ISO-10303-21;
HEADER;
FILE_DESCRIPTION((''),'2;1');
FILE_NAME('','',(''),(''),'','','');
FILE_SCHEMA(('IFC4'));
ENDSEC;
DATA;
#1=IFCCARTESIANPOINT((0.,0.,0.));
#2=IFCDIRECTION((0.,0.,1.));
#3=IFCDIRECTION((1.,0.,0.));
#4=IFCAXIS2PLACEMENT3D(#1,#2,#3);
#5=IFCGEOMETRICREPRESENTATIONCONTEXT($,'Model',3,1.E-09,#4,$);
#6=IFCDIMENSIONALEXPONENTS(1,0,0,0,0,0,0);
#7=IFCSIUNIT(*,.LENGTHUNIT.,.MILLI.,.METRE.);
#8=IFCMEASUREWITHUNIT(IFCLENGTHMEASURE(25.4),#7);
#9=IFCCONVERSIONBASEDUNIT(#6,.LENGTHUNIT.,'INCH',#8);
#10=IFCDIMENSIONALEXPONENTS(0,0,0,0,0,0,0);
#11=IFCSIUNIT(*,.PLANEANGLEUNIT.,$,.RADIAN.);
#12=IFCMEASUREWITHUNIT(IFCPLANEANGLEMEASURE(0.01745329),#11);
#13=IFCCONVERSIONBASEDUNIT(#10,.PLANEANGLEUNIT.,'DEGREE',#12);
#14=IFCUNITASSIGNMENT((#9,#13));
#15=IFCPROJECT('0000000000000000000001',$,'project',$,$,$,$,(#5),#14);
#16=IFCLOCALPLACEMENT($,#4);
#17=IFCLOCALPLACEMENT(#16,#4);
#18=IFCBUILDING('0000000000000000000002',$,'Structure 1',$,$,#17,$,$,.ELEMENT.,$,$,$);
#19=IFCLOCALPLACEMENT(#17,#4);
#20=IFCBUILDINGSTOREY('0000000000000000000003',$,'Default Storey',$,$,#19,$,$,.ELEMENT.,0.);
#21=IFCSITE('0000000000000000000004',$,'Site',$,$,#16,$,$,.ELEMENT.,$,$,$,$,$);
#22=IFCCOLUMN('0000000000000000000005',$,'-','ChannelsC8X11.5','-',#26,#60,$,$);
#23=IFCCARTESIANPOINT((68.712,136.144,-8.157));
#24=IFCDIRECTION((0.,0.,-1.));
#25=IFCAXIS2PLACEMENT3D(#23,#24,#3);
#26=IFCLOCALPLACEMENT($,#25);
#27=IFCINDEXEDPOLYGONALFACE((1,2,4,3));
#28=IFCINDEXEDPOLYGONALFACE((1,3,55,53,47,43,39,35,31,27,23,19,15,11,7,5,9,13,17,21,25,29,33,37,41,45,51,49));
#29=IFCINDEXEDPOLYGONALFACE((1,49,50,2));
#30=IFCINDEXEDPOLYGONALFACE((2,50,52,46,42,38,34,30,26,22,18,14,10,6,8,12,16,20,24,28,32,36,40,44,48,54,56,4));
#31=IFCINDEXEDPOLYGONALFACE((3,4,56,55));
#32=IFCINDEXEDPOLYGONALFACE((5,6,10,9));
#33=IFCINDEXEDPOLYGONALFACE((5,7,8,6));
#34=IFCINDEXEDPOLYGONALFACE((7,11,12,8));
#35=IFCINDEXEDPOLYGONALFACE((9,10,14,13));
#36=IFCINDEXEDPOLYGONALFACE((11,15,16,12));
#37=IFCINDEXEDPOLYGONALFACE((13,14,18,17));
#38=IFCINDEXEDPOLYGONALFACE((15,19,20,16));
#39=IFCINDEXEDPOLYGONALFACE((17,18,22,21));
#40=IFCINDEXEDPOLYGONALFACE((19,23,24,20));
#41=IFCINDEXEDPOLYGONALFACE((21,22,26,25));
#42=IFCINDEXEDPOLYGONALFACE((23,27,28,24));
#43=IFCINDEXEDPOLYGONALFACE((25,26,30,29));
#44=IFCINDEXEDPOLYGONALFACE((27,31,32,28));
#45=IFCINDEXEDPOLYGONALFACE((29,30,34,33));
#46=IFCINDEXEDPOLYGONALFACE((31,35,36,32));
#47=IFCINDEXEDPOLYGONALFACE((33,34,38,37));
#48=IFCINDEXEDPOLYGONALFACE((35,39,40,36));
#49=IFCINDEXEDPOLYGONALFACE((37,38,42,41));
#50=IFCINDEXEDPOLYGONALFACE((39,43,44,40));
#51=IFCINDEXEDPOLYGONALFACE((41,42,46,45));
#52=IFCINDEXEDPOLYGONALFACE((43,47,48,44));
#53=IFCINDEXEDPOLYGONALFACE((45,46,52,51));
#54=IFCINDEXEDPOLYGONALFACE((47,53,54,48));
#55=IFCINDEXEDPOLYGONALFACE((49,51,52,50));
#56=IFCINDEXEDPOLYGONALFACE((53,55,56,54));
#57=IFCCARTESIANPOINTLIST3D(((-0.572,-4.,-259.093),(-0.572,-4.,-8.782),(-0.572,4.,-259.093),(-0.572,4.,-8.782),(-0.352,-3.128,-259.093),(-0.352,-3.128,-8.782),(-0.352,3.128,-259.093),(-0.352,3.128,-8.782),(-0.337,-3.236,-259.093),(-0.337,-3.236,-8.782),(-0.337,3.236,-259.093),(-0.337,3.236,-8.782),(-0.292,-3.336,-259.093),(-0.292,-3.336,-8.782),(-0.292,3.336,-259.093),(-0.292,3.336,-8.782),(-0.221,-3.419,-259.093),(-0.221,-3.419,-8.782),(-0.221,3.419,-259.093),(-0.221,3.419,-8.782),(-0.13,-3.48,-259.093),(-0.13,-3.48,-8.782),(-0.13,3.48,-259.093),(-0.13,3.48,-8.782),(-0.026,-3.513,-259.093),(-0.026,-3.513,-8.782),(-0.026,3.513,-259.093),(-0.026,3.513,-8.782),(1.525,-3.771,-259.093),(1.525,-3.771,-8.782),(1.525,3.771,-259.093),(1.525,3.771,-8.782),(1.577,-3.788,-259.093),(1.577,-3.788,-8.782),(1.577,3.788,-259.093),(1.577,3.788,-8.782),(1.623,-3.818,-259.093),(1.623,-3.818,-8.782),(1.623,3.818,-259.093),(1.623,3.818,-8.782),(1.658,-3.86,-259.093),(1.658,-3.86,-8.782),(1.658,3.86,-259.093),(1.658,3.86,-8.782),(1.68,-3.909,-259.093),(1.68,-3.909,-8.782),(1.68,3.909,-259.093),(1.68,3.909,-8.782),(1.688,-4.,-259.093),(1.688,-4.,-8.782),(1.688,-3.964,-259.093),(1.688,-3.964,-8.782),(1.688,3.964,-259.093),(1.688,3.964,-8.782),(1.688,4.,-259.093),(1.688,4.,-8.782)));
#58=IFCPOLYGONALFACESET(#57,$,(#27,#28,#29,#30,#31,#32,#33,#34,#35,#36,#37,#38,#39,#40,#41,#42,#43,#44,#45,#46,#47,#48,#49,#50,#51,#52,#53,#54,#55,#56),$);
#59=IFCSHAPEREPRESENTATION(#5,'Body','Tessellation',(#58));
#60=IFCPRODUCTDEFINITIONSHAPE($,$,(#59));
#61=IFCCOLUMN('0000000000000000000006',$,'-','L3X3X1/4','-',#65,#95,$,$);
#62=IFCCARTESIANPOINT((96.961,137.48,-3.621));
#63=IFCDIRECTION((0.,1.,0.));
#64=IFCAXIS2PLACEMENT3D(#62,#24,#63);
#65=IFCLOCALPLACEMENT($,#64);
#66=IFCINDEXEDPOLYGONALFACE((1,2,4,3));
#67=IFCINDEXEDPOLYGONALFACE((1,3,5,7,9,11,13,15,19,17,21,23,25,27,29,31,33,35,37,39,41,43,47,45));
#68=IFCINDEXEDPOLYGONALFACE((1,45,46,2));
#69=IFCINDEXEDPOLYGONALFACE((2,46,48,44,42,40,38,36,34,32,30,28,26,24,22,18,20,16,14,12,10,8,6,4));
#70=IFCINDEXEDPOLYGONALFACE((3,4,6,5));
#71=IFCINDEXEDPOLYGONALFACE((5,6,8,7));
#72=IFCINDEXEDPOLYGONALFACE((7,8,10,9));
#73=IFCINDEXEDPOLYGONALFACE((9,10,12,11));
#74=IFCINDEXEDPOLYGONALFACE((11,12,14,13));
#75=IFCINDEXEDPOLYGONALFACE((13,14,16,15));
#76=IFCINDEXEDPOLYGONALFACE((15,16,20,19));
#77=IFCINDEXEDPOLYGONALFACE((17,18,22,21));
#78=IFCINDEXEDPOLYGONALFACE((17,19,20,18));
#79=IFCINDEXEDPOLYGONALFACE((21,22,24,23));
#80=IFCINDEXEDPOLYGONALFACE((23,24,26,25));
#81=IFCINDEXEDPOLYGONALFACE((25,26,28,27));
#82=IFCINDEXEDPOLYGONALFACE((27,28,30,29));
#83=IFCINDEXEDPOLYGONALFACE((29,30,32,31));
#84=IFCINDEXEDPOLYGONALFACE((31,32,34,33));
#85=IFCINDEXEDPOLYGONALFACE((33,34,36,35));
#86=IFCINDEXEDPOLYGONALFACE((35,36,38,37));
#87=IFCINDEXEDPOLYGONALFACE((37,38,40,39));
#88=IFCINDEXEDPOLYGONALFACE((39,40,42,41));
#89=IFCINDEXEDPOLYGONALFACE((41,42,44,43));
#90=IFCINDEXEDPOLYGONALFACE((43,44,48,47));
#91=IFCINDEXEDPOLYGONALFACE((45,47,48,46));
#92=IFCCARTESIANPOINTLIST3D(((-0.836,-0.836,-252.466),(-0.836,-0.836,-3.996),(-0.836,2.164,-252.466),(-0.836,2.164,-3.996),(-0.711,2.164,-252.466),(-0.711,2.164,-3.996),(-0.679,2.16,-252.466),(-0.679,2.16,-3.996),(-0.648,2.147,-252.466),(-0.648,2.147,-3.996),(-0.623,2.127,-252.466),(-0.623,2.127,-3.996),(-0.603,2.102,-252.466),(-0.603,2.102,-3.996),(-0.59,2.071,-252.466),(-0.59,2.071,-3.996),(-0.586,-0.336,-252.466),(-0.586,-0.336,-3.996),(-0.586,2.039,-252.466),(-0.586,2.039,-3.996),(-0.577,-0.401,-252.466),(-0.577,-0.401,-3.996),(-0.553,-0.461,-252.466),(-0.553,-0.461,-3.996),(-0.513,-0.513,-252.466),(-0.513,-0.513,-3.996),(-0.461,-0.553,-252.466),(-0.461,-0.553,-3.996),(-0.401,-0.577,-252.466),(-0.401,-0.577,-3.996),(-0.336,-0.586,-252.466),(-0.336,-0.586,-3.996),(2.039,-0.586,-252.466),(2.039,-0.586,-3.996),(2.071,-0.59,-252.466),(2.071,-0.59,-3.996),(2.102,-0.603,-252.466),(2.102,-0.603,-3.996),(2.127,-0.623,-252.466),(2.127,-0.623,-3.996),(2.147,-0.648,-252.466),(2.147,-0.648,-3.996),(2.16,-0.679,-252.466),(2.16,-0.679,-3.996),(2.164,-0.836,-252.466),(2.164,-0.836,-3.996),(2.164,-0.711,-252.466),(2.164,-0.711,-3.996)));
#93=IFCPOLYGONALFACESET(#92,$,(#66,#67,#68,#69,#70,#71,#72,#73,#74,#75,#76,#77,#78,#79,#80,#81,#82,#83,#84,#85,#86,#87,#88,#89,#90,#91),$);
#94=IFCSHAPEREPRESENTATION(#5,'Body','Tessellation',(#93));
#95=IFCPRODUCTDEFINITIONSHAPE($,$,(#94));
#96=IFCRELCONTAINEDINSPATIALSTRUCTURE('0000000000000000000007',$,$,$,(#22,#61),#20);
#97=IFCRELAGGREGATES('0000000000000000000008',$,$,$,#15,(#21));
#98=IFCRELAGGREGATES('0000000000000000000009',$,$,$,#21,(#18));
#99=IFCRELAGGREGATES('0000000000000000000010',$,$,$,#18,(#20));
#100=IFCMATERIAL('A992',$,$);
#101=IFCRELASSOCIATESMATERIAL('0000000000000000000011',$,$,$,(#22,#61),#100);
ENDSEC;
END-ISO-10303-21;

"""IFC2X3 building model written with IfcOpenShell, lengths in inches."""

from ifc_helpers import new_model, entity, si_unit, converted_unit, frame, frame_2d, origin, origin_with_axes, place, context, project, spatial, l_section, u_section, extrude, clip, halfspace, material, element, save


model = new_model("IFC2X3")

# Units and contexts
model_context = context("Model", 3, precision=1e-09, world=origin_with_axes())
ifc_project = project(units=[converted_unit("LENGTHUNIT", "INCH", entity("IfcLengthMeasure", 25.4), si_unit("LENGTHUNIT", "METRE", prefix="MILLI"), dimensions=[1, 0, 0, 0, 0, 0, 0]), converted_unit("PLANEANGLEUNIT", "DEGREE", entity("IfcPlaneAngleMeasure", 0.01745329), si_unit("PLANEANGLEUNIT", "RADIAN"), dimensions=[0, 0, 0, 0, 0, 0, 0])], contexts=[model_context])

# Site, building, storey
site_placement = place(None, origin_with_axes())
site = spatial("IfcSite", under=ifc_project, at=site_placement, Name="Site", CompositionType="ELEMENT")
building_placement = place(site_placement, origin_with_axes())
building = spatial("IfcBuilding", under=site, at=building_placement, Name="Structure 1", CompositionType="ELEMENT")
storey_placement = place(building_placement, origin_with_axes())
storey = spatial("IfcBuildingStorey", under=building, at=storey_placement, Name="Default Storey", CompositionType="ELEMENT", Elevation=0.0)

# Columns
ifc_material_1 = material(Name="A992")
column_1_placement = place(None, frame((68.712, 136.144, -8.157), z_axis=(0.0, 0.0, -1.0), x_axis=(1.0, 0.0, 0.0)))
element("IfcColumn", 1, at=column_1_placement, inside=storey, material=ifc_material_1, Name="-", Description="ChannelsC8X11.5", ObjectType="-", context=model_context, shape_type="Clipping", body=[
    clip(extrude(u_section(Depth=8.0, FlangeWidth=2.26, WebThickness=0.22, FlangeThickness=0.39, FilletRadius=0.39, EdgeRadius=0.195, FlangeSlope=9.462, at=frame_2d((0.558, 0.0))), origin(), (0.0, 0.0, -1.0), 259.093), halfspace(frame((-68.712, 136.144, -8.782), z_axis=(0.0, 0.0, -1.0), x_axis=(1.0, 0.0, 0.0)), True)),
])
column_2_placement = place(None, frame((96.961, 137.48, -3.621), z_axis=(0.0, 0.0, -1.0), x_axis=(0.0, 1.0, 0.0)))
element("IfcColumn", 2, at=column_2_placement, inside=storey, material=ifc_material_1, Name="-", Description="L3X3X1/4", ObjectType="-", context=model_context, shape_type="Clipping", body=[
    clip(extrude(l_section(Depth=3.0, Width=3.0, Thickness=0.25, FilletRadius=0.25, EdgeRadius=0.125, at=frame_2d((0.664, 0.664))), origin(), (0.0, 0.0, -1.0), 252.466), halfspace(frame((-137.48, -96.961, -3.996), z_axis=(0.0, 0.0, -1.0), x_axis=(0.0, 1.0, 0.0)), True)),
])

save(model, "model.ifc")
